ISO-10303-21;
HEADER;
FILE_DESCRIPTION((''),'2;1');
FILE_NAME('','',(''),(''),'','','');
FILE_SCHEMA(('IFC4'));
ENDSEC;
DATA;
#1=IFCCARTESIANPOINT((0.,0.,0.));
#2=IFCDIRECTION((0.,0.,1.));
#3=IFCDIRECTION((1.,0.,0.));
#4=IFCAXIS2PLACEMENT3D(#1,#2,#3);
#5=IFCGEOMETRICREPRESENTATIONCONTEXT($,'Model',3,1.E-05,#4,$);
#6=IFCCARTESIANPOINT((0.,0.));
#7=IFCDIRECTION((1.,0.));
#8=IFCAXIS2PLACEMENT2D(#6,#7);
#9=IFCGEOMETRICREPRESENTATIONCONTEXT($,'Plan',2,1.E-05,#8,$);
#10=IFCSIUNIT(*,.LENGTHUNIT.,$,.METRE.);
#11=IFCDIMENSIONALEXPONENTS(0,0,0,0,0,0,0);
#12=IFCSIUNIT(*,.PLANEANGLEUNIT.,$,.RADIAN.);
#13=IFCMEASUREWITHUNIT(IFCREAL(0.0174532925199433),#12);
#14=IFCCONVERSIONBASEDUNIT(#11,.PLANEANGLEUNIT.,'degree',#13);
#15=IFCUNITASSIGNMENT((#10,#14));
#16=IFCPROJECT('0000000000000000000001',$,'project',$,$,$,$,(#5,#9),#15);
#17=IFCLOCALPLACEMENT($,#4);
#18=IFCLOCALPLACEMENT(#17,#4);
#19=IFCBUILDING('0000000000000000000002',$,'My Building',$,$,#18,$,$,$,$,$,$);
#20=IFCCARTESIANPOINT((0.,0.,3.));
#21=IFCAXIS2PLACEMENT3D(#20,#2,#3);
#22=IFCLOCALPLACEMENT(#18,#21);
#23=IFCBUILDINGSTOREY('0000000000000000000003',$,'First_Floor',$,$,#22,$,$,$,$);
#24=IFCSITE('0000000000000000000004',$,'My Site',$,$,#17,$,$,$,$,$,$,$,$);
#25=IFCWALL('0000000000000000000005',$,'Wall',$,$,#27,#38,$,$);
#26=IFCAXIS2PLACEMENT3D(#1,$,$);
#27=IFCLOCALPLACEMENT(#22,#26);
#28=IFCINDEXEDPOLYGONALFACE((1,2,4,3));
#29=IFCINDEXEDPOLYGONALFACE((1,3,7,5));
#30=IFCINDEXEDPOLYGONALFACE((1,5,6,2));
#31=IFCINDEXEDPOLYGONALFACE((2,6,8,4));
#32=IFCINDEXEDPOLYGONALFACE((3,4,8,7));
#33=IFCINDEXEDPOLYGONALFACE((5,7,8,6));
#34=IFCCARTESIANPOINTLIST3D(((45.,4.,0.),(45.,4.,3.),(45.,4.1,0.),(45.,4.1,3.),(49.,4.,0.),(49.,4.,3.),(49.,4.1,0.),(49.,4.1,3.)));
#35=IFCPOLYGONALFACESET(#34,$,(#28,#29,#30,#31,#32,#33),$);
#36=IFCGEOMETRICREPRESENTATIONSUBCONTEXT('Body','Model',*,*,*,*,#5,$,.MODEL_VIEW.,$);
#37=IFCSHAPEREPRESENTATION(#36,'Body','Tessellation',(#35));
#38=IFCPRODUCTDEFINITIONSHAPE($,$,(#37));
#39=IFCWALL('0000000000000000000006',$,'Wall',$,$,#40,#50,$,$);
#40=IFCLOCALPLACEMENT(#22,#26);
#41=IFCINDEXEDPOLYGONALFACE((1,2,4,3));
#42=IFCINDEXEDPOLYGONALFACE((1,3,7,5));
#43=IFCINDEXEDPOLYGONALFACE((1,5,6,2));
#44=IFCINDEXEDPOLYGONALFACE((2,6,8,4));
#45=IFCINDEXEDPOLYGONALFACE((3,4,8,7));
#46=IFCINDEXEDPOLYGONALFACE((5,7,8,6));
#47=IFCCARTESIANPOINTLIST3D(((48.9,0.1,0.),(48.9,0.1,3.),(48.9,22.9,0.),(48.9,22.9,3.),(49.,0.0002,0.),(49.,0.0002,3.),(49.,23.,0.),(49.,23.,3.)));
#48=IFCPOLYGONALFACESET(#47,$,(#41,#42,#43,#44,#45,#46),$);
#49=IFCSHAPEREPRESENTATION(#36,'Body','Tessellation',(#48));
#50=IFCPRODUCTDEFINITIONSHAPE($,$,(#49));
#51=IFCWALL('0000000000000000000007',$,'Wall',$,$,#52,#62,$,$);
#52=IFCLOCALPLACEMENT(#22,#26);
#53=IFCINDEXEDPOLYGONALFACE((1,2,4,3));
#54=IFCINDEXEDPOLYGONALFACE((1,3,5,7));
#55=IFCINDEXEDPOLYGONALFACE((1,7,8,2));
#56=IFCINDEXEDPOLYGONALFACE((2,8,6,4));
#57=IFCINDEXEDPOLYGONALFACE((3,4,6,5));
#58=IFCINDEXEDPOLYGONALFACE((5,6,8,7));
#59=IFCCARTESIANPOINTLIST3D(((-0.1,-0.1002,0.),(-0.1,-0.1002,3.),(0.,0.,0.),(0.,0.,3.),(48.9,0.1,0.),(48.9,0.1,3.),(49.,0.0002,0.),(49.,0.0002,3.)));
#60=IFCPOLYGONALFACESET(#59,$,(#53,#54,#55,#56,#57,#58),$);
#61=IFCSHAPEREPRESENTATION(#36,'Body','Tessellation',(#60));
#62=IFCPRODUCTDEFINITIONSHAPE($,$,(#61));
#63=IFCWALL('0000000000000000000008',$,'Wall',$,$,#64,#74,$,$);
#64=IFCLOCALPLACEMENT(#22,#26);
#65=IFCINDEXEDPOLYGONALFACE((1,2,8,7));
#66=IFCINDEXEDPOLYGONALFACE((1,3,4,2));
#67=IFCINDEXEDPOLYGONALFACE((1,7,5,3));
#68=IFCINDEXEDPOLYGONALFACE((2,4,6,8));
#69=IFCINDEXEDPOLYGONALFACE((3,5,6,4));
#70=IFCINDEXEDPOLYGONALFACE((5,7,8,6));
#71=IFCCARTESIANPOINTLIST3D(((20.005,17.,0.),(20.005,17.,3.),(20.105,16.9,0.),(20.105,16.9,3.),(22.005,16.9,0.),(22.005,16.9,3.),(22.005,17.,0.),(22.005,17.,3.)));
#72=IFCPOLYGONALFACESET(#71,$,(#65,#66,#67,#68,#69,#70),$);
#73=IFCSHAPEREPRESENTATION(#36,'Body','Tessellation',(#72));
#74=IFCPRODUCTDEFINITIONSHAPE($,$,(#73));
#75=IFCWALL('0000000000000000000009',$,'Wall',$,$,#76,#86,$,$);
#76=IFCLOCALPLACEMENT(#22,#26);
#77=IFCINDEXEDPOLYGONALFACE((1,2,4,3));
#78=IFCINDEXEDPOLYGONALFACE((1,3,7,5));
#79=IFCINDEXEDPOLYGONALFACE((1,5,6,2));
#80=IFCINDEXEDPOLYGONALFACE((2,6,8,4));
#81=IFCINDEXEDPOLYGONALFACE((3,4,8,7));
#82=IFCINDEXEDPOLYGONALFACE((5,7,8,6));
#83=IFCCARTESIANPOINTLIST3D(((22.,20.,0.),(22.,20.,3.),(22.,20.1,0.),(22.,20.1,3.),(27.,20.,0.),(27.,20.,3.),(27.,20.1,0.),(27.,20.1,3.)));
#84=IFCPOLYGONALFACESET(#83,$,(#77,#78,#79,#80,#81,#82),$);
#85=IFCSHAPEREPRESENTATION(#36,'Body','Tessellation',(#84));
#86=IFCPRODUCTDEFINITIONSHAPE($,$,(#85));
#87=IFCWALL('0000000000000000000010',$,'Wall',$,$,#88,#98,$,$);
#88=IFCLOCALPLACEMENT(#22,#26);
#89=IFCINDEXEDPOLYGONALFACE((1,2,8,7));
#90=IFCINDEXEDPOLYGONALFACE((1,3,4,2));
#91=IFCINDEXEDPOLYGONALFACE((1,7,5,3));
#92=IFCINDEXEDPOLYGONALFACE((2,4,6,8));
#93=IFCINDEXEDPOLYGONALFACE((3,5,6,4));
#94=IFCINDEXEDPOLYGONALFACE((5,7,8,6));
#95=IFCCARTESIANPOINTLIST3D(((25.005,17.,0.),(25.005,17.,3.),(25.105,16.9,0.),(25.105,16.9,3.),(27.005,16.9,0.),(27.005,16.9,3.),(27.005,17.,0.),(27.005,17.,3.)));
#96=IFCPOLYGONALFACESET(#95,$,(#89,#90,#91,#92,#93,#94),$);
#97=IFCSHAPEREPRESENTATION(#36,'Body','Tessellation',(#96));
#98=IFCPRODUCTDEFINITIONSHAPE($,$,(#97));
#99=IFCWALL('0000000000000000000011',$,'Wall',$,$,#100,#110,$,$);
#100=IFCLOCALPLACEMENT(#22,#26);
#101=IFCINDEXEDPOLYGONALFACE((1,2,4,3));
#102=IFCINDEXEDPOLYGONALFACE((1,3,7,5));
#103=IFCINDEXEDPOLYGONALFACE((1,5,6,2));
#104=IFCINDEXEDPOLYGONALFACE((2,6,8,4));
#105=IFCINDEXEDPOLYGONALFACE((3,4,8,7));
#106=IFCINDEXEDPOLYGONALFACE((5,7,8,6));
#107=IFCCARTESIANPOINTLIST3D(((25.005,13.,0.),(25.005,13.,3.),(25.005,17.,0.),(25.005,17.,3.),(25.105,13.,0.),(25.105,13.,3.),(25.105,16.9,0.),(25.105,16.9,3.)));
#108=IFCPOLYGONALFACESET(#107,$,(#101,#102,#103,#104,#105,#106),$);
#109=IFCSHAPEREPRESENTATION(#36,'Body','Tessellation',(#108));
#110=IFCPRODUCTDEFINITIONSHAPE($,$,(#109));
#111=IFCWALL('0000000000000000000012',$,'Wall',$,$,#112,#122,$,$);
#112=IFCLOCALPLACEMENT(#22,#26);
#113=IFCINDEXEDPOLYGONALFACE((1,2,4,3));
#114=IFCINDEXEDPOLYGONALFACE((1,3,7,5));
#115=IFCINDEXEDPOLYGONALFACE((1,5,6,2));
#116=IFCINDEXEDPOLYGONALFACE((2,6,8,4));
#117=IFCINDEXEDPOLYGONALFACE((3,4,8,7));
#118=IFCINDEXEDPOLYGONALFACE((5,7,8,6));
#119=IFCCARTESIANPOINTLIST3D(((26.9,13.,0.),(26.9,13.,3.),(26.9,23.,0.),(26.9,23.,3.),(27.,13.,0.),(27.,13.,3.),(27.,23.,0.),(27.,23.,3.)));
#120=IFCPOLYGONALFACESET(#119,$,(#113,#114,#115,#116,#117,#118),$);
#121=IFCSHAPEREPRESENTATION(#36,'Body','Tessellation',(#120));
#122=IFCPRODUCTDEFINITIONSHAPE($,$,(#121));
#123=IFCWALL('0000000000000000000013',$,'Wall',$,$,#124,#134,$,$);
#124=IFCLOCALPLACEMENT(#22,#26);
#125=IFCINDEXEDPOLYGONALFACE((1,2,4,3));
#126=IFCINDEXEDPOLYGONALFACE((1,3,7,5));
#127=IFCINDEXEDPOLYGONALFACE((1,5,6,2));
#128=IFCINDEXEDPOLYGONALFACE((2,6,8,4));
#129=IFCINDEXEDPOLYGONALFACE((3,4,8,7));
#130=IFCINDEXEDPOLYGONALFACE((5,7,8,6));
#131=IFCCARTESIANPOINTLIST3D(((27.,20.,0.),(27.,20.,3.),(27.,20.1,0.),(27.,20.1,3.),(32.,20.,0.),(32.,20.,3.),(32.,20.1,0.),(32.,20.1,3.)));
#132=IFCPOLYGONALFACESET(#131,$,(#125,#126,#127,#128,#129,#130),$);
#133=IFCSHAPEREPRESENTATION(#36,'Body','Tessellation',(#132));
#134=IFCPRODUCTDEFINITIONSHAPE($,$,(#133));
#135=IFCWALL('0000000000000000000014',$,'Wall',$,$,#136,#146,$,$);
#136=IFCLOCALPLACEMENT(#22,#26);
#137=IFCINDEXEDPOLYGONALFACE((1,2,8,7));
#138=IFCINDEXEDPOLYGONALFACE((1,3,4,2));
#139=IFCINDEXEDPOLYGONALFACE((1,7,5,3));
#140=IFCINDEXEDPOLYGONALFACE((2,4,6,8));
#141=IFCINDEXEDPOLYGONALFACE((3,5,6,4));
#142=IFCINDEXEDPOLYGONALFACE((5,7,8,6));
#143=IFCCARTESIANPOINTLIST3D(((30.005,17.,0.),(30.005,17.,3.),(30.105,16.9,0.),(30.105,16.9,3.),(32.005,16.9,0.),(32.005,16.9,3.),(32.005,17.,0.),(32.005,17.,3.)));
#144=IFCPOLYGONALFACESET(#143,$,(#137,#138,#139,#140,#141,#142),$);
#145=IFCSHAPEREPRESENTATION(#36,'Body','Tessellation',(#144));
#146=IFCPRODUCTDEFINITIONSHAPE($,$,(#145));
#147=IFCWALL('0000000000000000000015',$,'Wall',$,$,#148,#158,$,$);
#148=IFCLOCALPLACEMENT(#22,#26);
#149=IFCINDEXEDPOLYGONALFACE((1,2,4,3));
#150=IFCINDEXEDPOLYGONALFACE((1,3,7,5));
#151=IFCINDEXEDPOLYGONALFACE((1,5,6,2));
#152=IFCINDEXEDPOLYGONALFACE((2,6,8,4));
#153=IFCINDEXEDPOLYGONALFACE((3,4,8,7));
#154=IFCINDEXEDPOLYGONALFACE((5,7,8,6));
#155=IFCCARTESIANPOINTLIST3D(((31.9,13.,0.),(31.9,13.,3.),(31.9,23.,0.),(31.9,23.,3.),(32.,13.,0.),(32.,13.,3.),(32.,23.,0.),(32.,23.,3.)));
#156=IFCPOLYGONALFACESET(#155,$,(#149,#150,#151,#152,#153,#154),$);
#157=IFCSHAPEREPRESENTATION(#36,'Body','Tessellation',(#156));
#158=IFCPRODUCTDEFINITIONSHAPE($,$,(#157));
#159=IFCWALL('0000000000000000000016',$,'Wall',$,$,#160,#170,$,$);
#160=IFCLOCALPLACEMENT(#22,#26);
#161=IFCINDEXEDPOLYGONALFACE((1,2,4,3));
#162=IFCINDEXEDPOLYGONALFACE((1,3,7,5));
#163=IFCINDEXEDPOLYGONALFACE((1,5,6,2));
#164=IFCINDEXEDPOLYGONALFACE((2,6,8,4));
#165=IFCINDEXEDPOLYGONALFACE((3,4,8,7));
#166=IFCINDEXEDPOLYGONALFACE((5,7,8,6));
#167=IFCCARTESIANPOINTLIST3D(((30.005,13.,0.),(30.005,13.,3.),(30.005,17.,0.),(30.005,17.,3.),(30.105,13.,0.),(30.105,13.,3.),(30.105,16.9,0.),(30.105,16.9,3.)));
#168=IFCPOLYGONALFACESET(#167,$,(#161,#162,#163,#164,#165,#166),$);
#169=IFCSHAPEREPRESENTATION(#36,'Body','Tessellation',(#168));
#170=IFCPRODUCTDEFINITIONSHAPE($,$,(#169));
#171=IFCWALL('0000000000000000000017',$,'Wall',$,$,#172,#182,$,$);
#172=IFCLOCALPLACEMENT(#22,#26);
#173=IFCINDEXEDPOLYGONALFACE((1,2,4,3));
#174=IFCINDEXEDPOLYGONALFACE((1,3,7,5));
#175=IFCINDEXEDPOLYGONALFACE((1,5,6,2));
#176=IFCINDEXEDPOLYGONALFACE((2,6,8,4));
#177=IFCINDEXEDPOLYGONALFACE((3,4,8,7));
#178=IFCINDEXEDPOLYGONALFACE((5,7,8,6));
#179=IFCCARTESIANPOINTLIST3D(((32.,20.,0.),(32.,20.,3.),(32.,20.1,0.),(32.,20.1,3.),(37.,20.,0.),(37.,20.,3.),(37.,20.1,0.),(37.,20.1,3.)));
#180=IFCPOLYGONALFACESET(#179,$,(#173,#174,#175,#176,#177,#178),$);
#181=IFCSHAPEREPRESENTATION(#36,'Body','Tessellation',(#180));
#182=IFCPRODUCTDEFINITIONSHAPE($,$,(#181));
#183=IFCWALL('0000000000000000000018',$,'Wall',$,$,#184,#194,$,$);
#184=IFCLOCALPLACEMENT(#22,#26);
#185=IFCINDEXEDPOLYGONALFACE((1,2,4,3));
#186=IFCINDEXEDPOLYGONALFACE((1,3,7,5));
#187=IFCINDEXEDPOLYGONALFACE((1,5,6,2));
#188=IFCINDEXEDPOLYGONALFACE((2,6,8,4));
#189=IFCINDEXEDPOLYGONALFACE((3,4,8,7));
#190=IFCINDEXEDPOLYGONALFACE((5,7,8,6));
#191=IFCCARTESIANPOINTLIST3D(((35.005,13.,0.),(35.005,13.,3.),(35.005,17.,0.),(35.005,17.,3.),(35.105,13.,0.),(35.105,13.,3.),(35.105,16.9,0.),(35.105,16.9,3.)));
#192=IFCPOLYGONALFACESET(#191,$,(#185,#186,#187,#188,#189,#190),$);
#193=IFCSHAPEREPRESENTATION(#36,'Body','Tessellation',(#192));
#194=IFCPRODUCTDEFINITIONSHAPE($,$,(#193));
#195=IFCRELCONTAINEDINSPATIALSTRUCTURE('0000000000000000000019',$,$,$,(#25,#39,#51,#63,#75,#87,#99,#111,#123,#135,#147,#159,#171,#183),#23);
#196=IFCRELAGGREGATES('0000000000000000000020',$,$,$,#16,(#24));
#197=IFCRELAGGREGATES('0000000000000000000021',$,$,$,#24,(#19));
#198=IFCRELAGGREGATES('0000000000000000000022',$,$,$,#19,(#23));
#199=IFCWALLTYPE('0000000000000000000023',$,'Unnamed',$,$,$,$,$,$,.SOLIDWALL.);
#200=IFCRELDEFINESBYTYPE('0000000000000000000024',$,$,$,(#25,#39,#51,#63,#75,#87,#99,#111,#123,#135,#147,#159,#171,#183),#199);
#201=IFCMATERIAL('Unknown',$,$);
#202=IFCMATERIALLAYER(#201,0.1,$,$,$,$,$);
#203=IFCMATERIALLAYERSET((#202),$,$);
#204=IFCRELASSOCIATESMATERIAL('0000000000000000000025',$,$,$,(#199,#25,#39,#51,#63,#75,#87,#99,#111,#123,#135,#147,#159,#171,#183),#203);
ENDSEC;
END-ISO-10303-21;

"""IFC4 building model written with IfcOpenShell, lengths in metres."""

from ifc_helpers import new_model, entity, si_unit, converted_unit, frame, origin_with_axes, origin_2d_with_axis, place, context, subcontext, project, spatial, line, indexed_curve, outline, extrude, material, layer, layer_set, layer_usage, type_object, element, save


model = new_model("IFC4")

# Units and contexts
model_context = context("Model", 3, precision=1e-05, world=origin_with_axes())
plan_context = context("Plan", 2, precision=1e-05, world=origin_2d_with_axis())
body_context = subcontext(model_context, "Body", "Model", "MODEL_VIEW")
ifc_project = project(units=[si_unit("LENGTHUNIT", "METRE"), converted_unit("PLANEANGLEUNIT", "degree", entity("IfcReal", 0.0174532925199433), si_unit("PLANEANGLEUNIT", "RADIAN"), dimensions=[0, 0, 0, 0, 0, 0, 0])], contexts=[model_context, plan_context])

# Site, building, storey
site_placement = place(None, origin_with_axes())
site = spatial("IfcSite", under=ifc_project, at=site_placement, Name="My Site")
building_placement = place(site_placement, origin_with_axes())
building = spatial("IfcBuilding", under=site, at=building_placement, Name="My Building")
storey_placement = place(building_placement, frame((0.0, 0.0, 3.0), z_axis=(0.0, 0.0, 1.0), x_axis=(1.0, 0.0, 0.0)))
storey = spatial("IfcBuildingStorey", under=building, at=storey_placement, Name="First_Floor")

# Walls
ifc_material = material(Name="Unknown")
ifc_layer = layer(ifc_material, 0.1)
ifc_layer_set = layer_set([ifc_layer])
wall_type = type_object("IfcWallType", Name="Unnamed", PredefinedType="SOLIDWALL", material=ifc_layer_set)
ifc_layer_usage_1 = layer_usage(ifc_layer_set, "AXIS2", "POSITIVE", 0.0)
wall_1_placement = place(storey_placement, frame((45.0, 4.0, 0.0), z_axis=(0.0, 0.0, 1.0), x_axis=(1.0, 0.0, 0.0)))
element("IfcWall", 1, at=wall_1_placement, inside=storey, type_object=wall_type, material=ifc_layer_usage_1, Name="Wall", context=body_context, shape_type="SweptSolid", body=[
    extrude(outline(indexed_curve([(0.0, 0.0), (0.0, 0.1), (4.0, 0.1), (4.0, 0.0)], segments=[line(1, 2, 3, 4, 1)])), origin_with_axes(), (0.0, 0.0, 1.0), 3.0),
])
ifc_layer_usage_2 = layer_usage(ifc_layer_set, "AXIS2", "POSITIVE", 0.0)
wall_2_placement = place(storey_placement, frame((48.9, 22.9, 0.0), z_axis=(0.0, 0.0, 1.0), x_axis=(0.0, -1.0, 0.0)))
element("IfcWall", 2, at=wall_2_placement, inside=storey, type_object=wall_type, material=ifc_layer_usage_2, Name="Wall", context=body_context, shape_type="SweptSolid", body=[
    extrude(outline(indexed_curve([(0.0, 0.0), (-0.1, 0.1), (22.8998, 0.1), (22.8, 0.0)], segments=[line(1, 2, 3, 4, 1)])), origin_with_axes(), (0.0, 0.0, 1.0), 3.0),
])
ifc_layer_usage_3 = layer_usage(ifc_layer_set, "AXIS2", "POSITIVE", 0.0)
wall_3_placement = place(storey_placement, frame((48.9, 0.1, 0.0), z_axis=(0.0, 0.0, 1.0), x_axis=(-0.999998, -0.002045, 0.0)))
element("IfcWall", 3, at=wall_3_placement, inside=storey, type_object=wall_type, material=ifc_layer_usage_3, Name="Wall", context=body_context, shape_type="SweptSolid", body=[
    extrude(outline(indexed_curve([(0.0, 0.0), (-0.0998, 0.1), (49.0003, 0.1), (48.9001, 0.0)], segments=[line(1, 2, 3, 4, 1)])), origin_with_axes(), (0.0, 0.0, 1.0), 3.0),
])
ifc_layer_usage_4 = layer_usage(ifc_layer_set, "AXIS2", "POSITIVE", 0.0)
wall_4_placement = place(storey_placement, frame((22.005, 17.0, 0.0), z_axis=(0.0, 0.0, 1.0), x_axis=(-1.0, 0.0, 0.0)))
element("IfcWall", 4, at=wall_4_placement, inside=storey, type_object=wall_type, material=ifc_layer_usage_4, Name="Wall", context=body_context, shape_type="SweptSolid", body=[
    extrude(outline(indexed_curve([(0.0, 0.0), (0.0, 0.1), (1.9, 0.1), (2.0, 0.0)], segments=[line(1, 2, 3, 4, 1)])), origin_with_axes(), (0.0, 0.0, 1.0), 3.0),
])
ifc_layer_usage_5 = layer_usage(ifc_layer_set, "AXIS2", "POSITIVE", 0.0)
wall_5_placement = place(storey_placement, frame((22.0, 20.0, 0.0), z_axis=(0.0, 0.0, 1.0), x_axis=(1.0, 0.0, 0.0)))
element("IfcWall", 5, at=wall_5_placement, inside=storey, type_object=wall_type, material=ifc_layer_usage_5, Name="Wall", context=body_context, shape_type="SweptSolid", body=[
    extrude(outline(indexed_curve([(0.0, 0.0), (0.0, 0.1), (5.0, 0.1), (5.0, 0.0)], segments=[line(1, 2, 3, 4, 1)])), origin_with_axes(), (0.0, 0.0, 1.0), 3.0),
])
ifc_layer_usage_6 = layer_usage(ifc_layer_set, "AXIS2", "POSITIVE", 0.0)
wall_6_placement = place(storey_placement, frame((27.005, 17.0, 0.0), z_axis=(0.0, 0.0, 1.0), x_axis=(-1.0, 0.0, 0.0)))
element("IfcWall", 6, at=wall_6_placement, inside=storey, type_object=wall_type, material=ifc_layer_usage_6, Name="Wall", context=body_context, shape_type="SweptSolid", body=[
    extrude(outline(indexed_curve([(0.0, 0.0), (0.0, 0.1), (1.9, 0.1), (2.0, 0.0)], segments=[line(1, 2, 3, 4, 1)])), origin_with_axes(), (0.0, 0.0, 1.0), 3.0),
])
ifc_layer_usage_7 = layer_usage(ifc_layer_set, "AXIS2", "POSITIVE", 0.0)
wall_7_placement = place(storey_placement, frame((25.005, 17.0, 0.0), z_axis=(0.0, 0.0, 1.0), x_axis=(0.0, -1.0, 0.0)))
element("IfcWall", 7, at=wall_7_placement, inside=storey, type_object=wall_type, material=ifc_layer_usage_7, Name="Wall", context=body_context, shape_type="SweptSolid", body=[
    extrude(outline(indexed_curve([(0.0, 0.0), (0.1, 0.1), (4.0, 0.1), (4.0, 0.0)], segments=[line(1, 2, 3, 4, 1)])), origin_with_axes(), (0.0, 0.0, 1.0), 3.0),
])
ifc_layer_usage_8 = layer_usage(ifc_layer_set, "AXIS2", "POSITIVE", 0.0)
wall_8_placement = place(storey_placement, frame((26.9, 23.0, 0.0), z_axis=(0.0, 0.0, 1.0), x_axis=(0.0, -1.0, 0.0)))
element("IfcWall", 8, at=wall_8_placement, inside=storey, type_object=wall_type, material=ifc_layer_usage_8, Name="Wall", context=body_context, shape_type="SweptSolid", body=[
    extrude(outline(indexed_curve([(0.0, 0.0), (0.0, 0.1), (10.0, 0.1), (10.0, 0.0)], segments=[line(1, 2, 3, 4, 1)])), origin_with_axes(), (0.0, 0.0, 1.0), 3.0),
])
ifc_layer_usage_9 = layer_usage(ifc_layer_set, "AXIS2", "POSITIVE", 0.0)
wall_9_placement = place(storey_placement, frame((27.0, 20.0, 0.0), z_axis=(0.0, 0.0, 1.0), x_axis=(1.0, 0.0, 0.0)))
element("IfcWall", 9, at=wall_9_placement, inside=storey, type_object=wall_type, material=ifc_layer_usage_9, Name="Wall", context=body_context, shape_type="SweptSolid", body=[
    extrude(outline(indexed_curve([(0.0, 0.0), (0.0, 0.1), (5.0, 0.1), (5.0, 0.0)], segments=[line(1, 2, 3, 4, 1)])), origin_with_axes(), (0.0, 0.0, 1.0), 3.0),
])
ifc_layer_usage_10 = layer_usage(ifc_layer_set, "AXIS2", "POSITIVE", 0.0)
wall_10_placement = place(storey_placement, frame((32.005, 17.0, 0.0), z_axis=(0.0, 0.0, 1.0), x_axis=(-1.0, 0.0, 0.0)))
element("IfcWall", 10, at=wall_10_placement, inside=storey, type_object=wall_type, material=ifc_layer_usage_10, Name="Wall", context=body_context, shape_type="SweptSolid", body=[
    extrude(outline(indexed_curve([(0.0, 0.0), (0.0, 0.1), (1.9, 0.1), (2.0, 0.0)], segments=[line(1, 2, 3, 4, 1)])), origin_with_axes(), (0.0, 0.0, 1.0), 3.0),
])
ifc_layer_usage_11 = layer_usage(ifc_layer_set, "AXIS2", "POSITIVE", 0.0)
wall_11_placement = place(storey_placement, frame((31.9, 23.0, 0.0), z_axis=(0.0, 0.0, 1.0), x_axis=(0.0, -1.0, 0.0)))
element("IfcWall", 11, at=wall_11_placement, inside=storey, type_object=wall_type, material=ifc_layer_usage_11, Name="Wall", context=body_context, shape_type="SweptSolid", body=[
    extrude(outline(indexed_curve([(0.0, 0.0), (0.0, 0.1), (10.0, 0.1), (10.0, 0.0)], segments=[line(1, 2, 3, 4, 1)])), origin_with_axes(), (0.0, 0.0, 1.0), 3.0),
])
ifc_layer_usage_12 = layer_usage(ifc_layer_set, "AXIS2", "POSITIVE", 0.0)
wall_12_placement = place(storey_placement, frame((30.005, 17.0, 0.0), z_axis=(0.0, 0.0, 1.0), x_axis=(0.0, -1.0, 0.0)))
element("IfcWall", 12, at=wall_12_placement, inside=storey, type_object=wall_type, material=ifc_layer_usage_12, Name="Wall", context=body_context, shape_type="SweptSolid", body=[
    extrude(outline(indexed_curve([(0.0, 0.0), (0.1, 0.1), (4.0, 0.1), (4.0, 0.0)], segments=[line(1, 2, 3, 4, 1)])), origin_with_axes(), (0.0, 0.0, 1.0), 3.0),
])
ifc_layer_usage_13 = layer_usage(ifc_layer_set, "AXIS2", "POSITIVE", 0.0)
wall_13_placement = place(storey_placement, frame((32.0, 20.0, 0.0), z_axis=(0.0, 0.0, 1.0), x_axis=(1.0, 0.0, 0.0)))
element("IfcWall", 13, at=wall_13_placement, inside=storey, type_object=wall_type, material=ifc_layer_usage_13, Name="Wall", context=body_context, shape_type="SweptSolid", body=[
    extrude(outline(indexed_curve([(0.0, 0.0), (0.0, 0.1), (5.0, 0.1), (5.0, 0.0)], segments=[line(1, 2, 3, 4, 1)])), origin_with_axes(), (0.0, 0.0, 1.0), 3.0),
])
ifc_layer_usage_14 = layer_usage(ifc_layer_set, "AXIS2", "POSITIVE", 0.0)
wall_14_placement = place(storey_placement, frame((35.005, 17.0, 0.0), z_axis=(0.0, 0.0, 1.0), x_axis=(0.0, -1.0, 0.0)))
element("IfcWall", 14, at=wall_14_placement, inside=storey, type_object=wall_type, material=ifc_layer_usage_14, Name="Wall", context=body_context, shape_type="SweptSolid", body=[
    extrude(outline(indexed_curve([(0.0, 0.0), (0.1, 0.1), (4.0, 0.1), (4.0, 0.0)], segments=[line(1, 2, 3, 4, 1)])), origin_with_axes(), (0.0, 0.0, 1.0), 3.0),
])

save(model, "model.ifc")
